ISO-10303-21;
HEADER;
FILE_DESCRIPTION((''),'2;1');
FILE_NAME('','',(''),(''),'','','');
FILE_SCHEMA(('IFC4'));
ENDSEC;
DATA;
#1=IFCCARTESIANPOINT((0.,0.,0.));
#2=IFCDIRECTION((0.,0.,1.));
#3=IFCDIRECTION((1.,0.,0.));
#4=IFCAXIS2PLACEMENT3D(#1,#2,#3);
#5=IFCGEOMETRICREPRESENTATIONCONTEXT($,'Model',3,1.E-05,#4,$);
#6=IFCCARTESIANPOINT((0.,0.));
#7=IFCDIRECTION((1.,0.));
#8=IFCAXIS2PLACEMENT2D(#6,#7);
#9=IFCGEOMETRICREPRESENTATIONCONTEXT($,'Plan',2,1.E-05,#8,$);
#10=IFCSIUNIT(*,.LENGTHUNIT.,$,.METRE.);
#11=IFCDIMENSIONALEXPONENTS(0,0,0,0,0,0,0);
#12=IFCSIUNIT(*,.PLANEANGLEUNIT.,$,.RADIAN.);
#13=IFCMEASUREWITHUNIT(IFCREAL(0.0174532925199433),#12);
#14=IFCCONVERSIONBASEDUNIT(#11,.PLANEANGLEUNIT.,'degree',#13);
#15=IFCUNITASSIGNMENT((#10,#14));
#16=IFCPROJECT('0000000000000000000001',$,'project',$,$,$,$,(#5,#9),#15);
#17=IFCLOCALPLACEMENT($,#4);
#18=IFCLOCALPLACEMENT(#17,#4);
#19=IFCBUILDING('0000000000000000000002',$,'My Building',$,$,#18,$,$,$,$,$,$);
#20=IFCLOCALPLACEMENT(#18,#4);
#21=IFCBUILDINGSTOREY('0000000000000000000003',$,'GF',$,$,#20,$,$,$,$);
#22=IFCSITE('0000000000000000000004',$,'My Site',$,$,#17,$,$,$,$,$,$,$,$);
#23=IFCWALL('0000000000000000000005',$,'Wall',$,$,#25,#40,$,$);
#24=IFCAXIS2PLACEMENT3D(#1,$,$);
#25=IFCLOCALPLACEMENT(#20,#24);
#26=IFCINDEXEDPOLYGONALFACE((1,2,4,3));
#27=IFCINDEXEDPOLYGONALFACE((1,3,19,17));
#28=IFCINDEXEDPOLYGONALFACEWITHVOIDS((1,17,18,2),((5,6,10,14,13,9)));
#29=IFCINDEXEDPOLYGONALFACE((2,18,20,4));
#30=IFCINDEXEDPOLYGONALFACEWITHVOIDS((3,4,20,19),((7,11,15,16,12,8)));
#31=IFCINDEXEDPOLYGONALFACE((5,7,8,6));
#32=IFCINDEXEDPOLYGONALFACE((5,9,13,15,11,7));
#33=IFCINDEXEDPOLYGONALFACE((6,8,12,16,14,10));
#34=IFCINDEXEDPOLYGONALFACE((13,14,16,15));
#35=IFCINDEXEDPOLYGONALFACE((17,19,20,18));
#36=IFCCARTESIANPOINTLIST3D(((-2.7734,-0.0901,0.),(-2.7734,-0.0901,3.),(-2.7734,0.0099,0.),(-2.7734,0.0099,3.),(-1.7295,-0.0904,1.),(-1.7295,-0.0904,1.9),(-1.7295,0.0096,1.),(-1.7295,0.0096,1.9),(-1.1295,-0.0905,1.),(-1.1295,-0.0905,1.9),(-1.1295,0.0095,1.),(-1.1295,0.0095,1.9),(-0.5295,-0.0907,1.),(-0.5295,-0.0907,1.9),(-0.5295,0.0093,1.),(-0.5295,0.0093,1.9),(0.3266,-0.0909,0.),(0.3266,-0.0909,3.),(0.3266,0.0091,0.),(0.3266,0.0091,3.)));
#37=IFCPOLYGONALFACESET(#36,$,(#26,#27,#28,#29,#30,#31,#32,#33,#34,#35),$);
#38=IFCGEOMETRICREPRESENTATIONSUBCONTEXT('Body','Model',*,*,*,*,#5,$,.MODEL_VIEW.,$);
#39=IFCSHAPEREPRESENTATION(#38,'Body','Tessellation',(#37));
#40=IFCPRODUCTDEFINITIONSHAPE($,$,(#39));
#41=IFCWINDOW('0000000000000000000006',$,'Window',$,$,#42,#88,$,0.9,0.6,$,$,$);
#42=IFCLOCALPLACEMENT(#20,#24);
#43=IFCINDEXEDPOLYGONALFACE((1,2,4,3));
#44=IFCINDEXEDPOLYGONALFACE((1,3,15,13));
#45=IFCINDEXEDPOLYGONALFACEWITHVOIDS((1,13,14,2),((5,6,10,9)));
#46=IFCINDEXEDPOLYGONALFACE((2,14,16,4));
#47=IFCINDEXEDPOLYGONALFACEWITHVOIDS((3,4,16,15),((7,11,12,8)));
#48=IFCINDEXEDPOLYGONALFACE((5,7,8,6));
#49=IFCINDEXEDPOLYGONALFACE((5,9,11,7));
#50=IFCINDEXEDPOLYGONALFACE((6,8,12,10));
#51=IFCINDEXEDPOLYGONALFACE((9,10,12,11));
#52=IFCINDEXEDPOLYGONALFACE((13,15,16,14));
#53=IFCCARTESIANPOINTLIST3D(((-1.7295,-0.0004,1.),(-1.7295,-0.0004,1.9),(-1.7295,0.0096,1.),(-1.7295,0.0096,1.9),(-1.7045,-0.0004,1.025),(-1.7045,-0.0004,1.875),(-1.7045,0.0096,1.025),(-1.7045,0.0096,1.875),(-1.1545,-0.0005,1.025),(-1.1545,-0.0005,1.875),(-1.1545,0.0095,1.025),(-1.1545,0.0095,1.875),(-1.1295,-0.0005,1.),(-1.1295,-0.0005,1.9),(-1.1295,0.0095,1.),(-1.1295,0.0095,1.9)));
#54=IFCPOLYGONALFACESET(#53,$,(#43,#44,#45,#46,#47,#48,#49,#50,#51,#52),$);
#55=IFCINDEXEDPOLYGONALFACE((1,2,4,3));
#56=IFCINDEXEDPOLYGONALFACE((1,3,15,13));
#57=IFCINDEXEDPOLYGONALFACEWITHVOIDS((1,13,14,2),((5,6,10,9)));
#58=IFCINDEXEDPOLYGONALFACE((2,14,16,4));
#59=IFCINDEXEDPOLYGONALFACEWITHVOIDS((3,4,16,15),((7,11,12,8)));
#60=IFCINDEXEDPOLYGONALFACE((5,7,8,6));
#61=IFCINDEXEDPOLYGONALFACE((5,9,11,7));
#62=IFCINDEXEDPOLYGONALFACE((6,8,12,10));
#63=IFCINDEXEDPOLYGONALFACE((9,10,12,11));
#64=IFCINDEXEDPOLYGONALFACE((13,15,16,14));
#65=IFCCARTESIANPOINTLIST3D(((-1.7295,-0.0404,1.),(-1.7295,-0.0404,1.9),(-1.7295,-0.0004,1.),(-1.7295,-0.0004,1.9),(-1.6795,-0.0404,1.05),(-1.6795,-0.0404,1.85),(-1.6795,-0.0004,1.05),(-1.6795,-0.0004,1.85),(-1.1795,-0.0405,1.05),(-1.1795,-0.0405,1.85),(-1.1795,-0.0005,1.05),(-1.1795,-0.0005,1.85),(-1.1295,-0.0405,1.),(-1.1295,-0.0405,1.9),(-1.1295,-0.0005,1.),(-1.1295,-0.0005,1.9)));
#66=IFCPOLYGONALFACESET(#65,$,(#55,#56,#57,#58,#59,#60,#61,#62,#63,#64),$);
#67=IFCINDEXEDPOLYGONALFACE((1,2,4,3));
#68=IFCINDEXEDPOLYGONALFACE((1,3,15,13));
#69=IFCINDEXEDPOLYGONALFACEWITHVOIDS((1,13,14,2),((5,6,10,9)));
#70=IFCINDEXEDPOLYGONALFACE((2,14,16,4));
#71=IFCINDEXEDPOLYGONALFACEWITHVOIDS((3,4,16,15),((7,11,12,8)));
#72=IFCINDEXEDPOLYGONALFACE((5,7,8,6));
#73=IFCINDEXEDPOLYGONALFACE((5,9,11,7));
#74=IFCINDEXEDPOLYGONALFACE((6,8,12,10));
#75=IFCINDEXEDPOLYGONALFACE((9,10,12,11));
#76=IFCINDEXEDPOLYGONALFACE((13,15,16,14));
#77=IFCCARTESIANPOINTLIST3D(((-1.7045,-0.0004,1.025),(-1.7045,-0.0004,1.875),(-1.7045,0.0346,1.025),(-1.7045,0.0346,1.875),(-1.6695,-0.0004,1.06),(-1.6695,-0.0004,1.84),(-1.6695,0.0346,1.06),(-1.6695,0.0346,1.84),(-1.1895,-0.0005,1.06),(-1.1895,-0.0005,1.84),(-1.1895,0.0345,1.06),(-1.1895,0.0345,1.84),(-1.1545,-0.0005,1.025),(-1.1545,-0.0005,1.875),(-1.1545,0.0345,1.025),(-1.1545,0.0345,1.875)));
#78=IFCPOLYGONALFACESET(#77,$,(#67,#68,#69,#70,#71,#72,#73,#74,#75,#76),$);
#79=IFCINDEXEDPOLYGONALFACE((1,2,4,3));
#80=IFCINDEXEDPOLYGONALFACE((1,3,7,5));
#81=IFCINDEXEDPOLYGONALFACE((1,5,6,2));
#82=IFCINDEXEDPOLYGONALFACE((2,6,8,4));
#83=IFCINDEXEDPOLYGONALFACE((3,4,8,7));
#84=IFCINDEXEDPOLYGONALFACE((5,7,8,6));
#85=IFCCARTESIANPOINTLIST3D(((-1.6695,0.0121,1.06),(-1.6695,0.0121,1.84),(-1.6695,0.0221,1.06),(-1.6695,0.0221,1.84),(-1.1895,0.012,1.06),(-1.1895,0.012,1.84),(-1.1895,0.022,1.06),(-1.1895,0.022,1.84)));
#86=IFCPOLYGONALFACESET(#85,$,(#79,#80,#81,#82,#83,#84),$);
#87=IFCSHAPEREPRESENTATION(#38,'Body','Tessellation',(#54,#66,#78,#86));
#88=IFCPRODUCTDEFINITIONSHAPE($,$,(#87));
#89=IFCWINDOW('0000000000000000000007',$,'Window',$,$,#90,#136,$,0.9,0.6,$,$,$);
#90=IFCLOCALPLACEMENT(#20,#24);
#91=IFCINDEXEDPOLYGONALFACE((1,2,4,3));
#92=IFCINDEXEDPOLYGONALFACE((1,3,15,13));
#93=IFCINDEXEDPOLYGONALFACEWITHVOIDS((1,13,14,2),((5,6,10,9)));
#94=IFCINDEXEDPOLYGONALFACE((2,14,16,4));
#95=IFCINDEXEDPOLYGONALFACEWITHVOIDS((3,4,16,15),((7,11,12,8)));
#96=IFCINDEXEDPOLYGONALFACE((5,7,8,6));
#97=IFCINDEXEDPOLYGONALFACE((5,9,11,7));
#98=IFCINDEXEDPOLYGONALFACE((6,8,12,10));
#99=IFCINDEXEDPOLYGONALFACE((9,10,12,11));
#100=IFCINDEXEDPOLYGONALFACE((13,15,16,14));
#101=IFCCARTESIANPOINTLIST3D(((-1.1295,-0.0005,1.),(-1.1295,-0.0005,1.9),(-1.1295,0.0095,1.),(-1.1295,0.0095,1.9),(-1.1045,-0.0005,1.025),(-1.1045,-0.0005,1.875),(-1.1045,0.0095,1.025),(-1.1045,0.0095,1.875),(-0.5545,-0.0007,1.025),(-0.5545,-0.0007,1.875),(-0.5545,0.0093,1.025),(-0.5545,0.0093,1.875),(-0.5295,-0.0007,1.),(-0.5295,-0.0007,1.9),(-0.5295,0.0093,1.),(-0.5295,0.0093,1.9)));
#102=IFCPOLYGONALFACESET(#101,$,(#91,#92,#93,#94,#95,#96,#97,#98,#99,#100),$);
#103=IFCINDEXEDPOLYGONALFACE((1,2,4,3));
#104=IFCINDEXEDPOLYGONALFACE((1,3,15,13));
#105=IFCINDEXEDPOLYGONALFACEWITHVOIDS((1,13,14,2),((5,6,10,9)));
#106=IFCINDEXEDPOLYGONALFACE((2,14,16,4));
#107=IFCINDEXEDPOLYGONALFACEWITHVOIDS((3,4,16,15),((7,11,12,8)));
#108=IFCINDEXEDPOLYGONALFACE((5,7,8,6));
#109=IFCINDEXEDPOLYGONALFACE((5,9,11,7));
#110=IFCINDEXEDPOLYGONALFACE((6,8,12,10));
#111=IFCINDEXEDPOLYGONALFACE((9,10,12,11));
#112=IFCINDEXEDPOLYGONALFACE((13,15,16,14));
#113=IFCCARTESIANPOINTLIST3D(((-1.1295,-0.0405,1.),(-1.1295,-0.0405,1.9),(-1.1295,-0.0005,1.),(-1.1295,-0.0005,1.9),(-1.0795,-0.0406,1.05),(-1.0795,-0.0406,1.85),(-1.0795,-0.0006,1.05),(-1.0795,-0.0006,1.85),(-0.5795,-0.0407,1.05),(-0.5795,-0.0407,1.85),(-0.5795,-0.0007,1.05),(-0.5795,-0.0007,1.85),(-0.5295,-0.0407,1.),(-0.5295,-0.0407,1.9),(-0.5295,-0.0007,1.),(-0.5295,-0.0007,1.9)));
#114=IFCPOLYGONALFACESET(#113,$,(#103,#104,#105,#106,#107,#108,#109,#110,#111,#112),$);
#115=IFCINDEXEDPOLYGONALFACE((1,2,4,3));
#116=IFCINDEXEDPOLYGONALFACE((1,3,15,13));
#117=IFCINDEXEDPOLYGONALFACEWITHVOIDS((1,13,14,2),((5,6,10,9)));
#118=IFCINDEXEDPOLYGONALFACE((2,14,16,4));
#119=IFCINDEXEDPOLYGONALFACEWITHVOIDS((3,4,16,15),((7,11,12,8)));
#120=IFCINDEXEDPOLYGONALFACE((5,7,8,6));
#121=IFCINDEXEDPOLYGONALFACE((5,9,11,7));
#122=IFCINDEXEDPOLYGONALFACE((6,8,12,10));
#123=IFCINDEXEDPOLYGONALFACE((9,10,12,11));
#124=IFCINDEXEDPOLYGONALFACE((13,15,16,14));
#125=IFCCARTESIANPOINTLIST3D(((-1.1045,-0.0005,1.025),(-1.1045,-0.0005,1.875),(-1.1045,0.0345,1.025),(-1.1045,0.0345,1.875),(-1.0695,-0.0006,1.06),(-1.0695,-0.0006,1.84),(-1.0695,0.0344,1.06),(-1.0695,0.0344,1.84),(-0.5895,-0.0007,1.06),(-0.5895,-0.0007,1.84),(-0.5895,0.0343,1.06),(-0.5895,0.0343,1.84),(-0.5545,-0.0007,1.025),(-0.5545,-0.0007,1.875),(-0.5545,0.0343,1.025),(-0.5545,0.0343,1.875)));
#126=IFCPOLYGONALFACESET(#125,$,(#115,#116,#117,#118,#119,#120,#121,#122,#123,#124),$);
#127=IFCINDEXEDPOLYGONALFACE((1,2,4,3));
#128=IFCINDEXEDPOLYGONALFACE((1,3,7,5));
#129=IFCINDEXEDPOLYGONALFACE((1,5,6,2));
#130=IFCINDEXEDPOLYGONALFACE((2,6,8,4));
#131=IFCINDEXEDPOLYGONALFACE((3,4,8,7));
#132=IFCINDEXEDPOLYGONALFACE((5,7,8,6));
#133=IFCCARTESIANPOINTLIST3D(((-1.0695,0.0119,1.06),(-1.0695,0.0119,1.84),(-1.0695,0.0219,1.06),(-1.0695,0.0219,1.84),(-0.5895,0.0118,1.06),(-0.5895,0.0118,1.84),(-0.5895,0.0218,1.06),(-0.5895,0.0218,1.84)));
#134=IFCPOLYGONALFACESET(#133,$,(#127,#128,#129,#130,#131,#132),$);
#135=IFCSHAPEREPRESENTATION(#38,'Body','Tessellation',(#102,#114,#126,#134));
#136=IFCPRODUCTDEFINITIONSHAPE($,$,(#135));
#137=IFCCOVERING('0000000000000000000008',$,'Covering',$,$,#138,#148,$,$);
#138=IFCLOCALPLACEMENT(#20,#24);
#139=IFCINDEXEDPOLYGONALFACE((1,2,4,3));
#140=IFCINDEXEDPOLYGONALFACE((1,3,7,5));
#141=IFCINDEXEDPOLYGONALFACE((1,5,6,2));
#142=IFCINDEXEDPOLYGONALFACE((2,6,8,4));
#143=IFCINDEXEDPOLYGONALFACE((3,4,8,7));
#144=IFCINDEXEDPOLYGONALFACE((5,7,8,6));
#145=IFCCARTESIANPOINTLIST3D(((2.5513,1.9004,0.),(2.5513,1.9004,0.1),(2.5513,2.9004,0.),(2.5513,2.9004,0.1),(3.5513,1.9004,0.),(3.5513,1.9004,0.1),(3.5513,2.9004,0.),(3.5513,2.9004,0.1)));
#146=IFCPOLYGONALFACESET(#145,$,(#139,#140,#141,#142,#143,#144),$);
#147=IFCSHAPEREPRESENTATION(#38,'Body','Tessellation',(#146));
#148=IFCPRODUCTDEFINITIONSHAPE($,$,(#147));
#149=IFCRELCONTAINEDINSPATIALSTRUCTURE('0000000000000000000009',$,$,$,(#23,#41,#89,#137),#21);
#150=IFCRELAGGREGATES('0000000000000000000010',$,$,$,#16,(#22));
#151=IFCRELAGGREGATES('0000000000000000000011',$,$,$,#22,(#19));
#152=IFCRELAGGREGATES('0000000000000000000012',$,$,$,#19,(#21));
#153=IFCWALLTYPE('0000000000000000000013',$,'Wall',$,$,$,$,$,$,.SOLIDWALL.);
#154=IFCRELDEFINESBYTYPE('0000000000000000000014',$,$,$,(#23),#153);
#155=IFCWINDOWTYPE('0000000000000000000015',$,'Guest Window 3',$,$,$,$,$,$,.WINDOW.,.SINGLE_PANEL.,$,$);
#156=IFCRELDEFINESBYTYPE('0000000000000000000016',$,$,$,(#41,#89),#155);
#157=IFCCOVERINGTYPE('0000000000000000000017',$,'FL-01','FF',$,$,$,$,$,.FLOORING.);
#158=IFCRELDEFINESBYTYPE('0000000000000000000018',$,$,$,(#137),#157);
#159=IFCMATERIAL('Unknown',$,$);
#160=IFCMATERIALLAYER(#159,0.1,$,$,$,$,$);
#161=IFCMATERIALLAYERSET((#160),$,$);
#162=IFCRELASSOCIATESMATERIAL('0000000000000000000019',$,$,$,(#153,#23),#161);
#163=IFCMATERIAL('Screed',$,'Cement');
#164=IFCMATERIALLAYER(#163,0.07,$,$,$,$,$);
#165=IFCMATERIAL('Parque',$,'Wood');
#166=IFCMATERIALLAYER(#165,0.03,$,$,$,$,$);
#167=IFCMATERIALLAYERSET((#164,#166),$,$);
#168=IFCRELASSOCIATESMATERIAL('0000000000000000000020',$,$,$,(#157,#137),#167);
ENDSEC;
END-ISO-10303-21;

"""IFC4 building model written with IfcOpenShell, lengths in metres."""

from ifc_helpers import new_model, entity, si_unit, converted_unit, frame, origin_with_axes, origin_2d_with_axis, place, context, subcontext, project, spatial, line, indexed_curve, outline, extrude, shape, source, transform, mapped, material, layer, layer_set, layer_usage, type_object, type_shapes, element, fill, save


model = new_model("IFC4")

# Units and contexts
model_context = context("Model", 3, precision=1e-05, world=origin_with_axes())
plan_context = context("Plan", 2, precision=1e-05, world=origin_2d_with_axis())
body_context_1 = subcontext(model_context, "Body", "Model", "MODEL_VIEW")
body_context_2 = subcontext(plan_context, "Body", "Plan", "PLAN_VIEW")
ifc_project = project(units=[si_unit("LENGTHUNIT", "METRE"), converted_unit("PLANEANGLEUNIT", "degree", entity("IfcReal", 0.0174532925199433), si_unit("PLANEANGLEUNIT", "RADIAN"), dimensions=[0, 0, 0, 0, 0, 0, 0])], contexts=[model_context, plan_context])

# Site, building, storey
site_placement = place(None, origin_with_axes())
site = spatial("IfcSite", under=ifc_project, at=site_placement, Name="My Site")
building_placement = place(site_placement, origin_with_axes())
building = spatial("IfcBuilding", under=site, at=building_placement, Name="My Building")
storey_placement = place(building_placement, origin_with_axes())
storey = spatial("IfcBuildingStorey", under=building, at=storey_placement, Name="GF")

# Shared definitions
ifc_material_1 = material(Name="Unknown")

# Shared definitions
ifc_layer_1 = layer(ifc_material_1, 0.1)
ifc_layer_set_1 = layer_set([ifc_layer_1])
wall_type = type_object("IfcWallType", Name="Wall", PredefinedType="SOLIDWALL", material=ifc_layer_set_1)

# Wall, openings, windows
ifc_layer_usage_1 = layer_usage(ifc_layer_set_1, "AXIS2", "POSITIVE", 0.0)
wall_1_placement = place(storey_placement, frame((-2.7734, -0.0901, 0.0), z_axis=(0.0, 0.0, 1.0), x_axis=(1.0, -0.000264, 0.0)))
wall_1 = element("IfcWall", 1, at=wall_1_placement, inside=storey, type_object=wall_type, material=ifc_layer_usage_1, Name="Wall", context=body_context_1, shape_type="SweptSolid", body=[
    extrude(outline(indexed_curve([(0.0, 0.0), (0.0, 0.1), (3.1, 0.1), (3.1, 0.0)], segments=[line(1, 2, 3, 4, 1)])), origin_with_axes(), (0.0, 0.0, 1.0), 3.0),
])
shared_shape_1 = source(origin_with_axes(), body_context_1, "Body", "SweptSolid", [
    extrude(outline(indexed_curve([(0.0, 0.0), (0.6, 0.0), (0.6, 0.9), (0.0, 0.9)], segments=[line(1, 2, 3, 4, 1)])), frame((0.0, -0.6, 0.0), z_axis=(0.0, -1.0, 0.0), x_axis=(1.0, 0.0, 0.0)), (0.0, 0.0, -1.0), 1.2),
])
opening_1_placement = place(wall_1_placement, frame((1.0439, 0.0, 1.0), z_axis=(0.0, 0.0, 1.0), x_axis=(1.0, 0.0, 0.0)))
opening_1 = element("IfcOpeningElement", 2, at=opening_1_placement, cuts=wall_1, PredefinedType="OPENING", context=body_context_1, shape_type="MappedRepresentation", body=[
    mapped(shared_shape_1, transform((0.0, 0.0, 0.0), x_axis=(1.0, 0.0, 0.0), y_axis=(0.0, 1.0, 0.0), z_axis=(0.0, 0.0, 1.0), scale=1.0)),
])
opening_2_placement = place(wall_1_placement, frame((1.6439, 0.0, 1.0), z_axis=(0.0, 0.0, 1.0), x_axis=(1.0, 0.0, 0.0)))
opening_2 = element("IfcOpeningElement", 3, at=opening_2_placement, cuts=wall_1, PredefinedType="OPENING", context=body_context_1, shape_type="MappedRepresentation", body=[
    mapped(shared_shape_1, transform((0.0, 0.0, 0.0), x_axis=(1.0, 0.0, 0.0), y_axis=(0.0, 1.0, 0.0), z_axis=(0.0, 0.0, 1.0), scale=1.0)),
])
window_type_1 = type_object("IfcWindowType", Name="Guest Window 3", PartitioningType="SINGLE_PANEL", PredefinedType="WINDOW")
shared_shape_2 = source(origin_with_axes(), body_context_1, "Body", "SweptSolid", [
    extrude(outline(indexed_curve([(0.0, 0.0), (0.6, 0.0), (0.6, 0.9), (0.0, 0.9)], segments=[line(1, 2, 3, 4, 1)]), holes=[indexed_curve([(0.025, 0.025), (0.575, 0.025), (0.575, 0.875), (0.025, 0.875)], segments=[line(1, 2, 3, 4, 1)])]), frame((0.0, 0.09, 0.0), z_axis=(0.0, -1.0, 0.0), x_axis=(1.0, 0.0, 0.0)), (0.0, 0.0, -1.0), 0.01),
    extrude(outline(indexed_curve([(0.0, 0.0), (0.6, 0.0), (0.6, 0.9), (0.0, 0.9)], segments=[line(1, 2, 3, 4, 1)]), holes=[indexed_curve([(0.05, 0.05), (0.55, 0.05), (0.55, 0.85), (0.05, 0.85)], segments=[line(1, 2, 3, 4, 1)])]), frame((0.0, 0.05, 0.0), z_axis=(0.0, -1.0, 0.0), x_axis=(1.0, 0.0, 0.0)), (0.0, 0.0, -1.0), 0.04),
    extrude(outline(indexed_curve([(0.0, 0.0), (0.55, 0.0), (0.55, 0.85), (0.0, 0.85)], segments=[line(1, 2, 3, 4, 1)]), holes=[indexed_curve([(0.035, 0.035), (0.515, 0.035), (0.515, 0.815), (0.035, 0.815)], segments=[line(1, 2, 3, 4, 1)])]), frame((0.025, 0.09, 0.025), z_axis=(0.0, -1.0, 0.0), x_axis=(1.0, 0.0, 0.0)), (0.0, 0.0, -1.0), 0.035),
    extrude(outline(indexed_curve([(0.035, 0.035), (0.515, 0.035), (0.515, 0.815), (0.035, 0.815)], segments=[line(1, 2, 3, 4, 1)])), frame((0.025, 0.1025, 0.025), z_axis=(0.0, -1.0, 0.0), x_axis=(1.0, 0.0, 0.0)), (0.0, 0.0, -1.0), 0.01),
])
shared_shape_3 = source(origin_with_axes(), body_context_2, "Body", "Curve2D", [
    entity("IfcIndexedPolyCurve", entity("IfcCartesianPointList2D", [[0.05, 0.05], [0.55, 0.05]])),
    entity("IfcIndexedPolyCurve", entity("IfcCartesianPointList2D", [[0.0, 0.1], [0.025, 0.1], [0.025, 0.09], [0.05, 0.09], [0.05, 0.05], [0.0, 0.05]]), [entity("IfcLineIndex", [1, 2, 3, 4, 5, 6, 1])]),
    entity("IfcIndexedPolyCurve", entity("IfcCartesianPointList2D", [[0.6, 0.1], [0.575, 0.1], [0.575, 0.09], [0.55, 0.09], [0.55, 0.05], [0.6, 0.05]]), [entity("IfcLineIndex", [1, 2, 3, 4, 5, 6, 1])]),
    entity("IfcIndexedPolyCurve", entity("IfcCartesianPointList2D", [[0.025, 0.09], [0.06, 0.09], [0.06, 0.125], [0.025, 0.125]]), [entity("IfcLineIndex", [1, 2, 3, 4, 1])]),
    entity("IfcIndexedPolyCurve", entity("IfcCartesianPointList2D", [[0.575, 0.09], [0.54, 0.09], [0.54, 0.125], [0.575, 0.125]]), [entity("IfcLineIndex", [1, 2, 3, 4, 1])]),
    entity("IfcIndexedPolyCurve", entity("IfcCartesianPointList2D", [[0.06, 0.09], [0.54, 0.09]])),
    entity("IfcIndexedPolyCurve", entity("IfcCartesianPointList2D", [[0.06, 0.125], [0.54, 0.125]])),
    entity("IfcIndexedPolyCurve", entity("IfcCartesianPointList2D", [[0.06, 0.1075], [0.54, 0.1075]])),
])
type_shapes(window_type_1, [shared_shape_2, shared_shape_3])
window_1_placement = place(opening_1_placement, frame((0.0, 0.0, 0.0), z_axis=(0.0, 0.0, 1.0), x_axis=(1.0, 0.0, 0.0)))
window_1 = element("IfcWindow", 4, at=window_1_placement, inside=storey, type_object=window_type_1, Name="Window", OverallHeight=0.9, OverallWidth=0.6, shapes=[
    shape(body_context_1, "Body", "MappedRepresentation", [mapped(shared_shape_2, transform((0.0, 0.0, 0.0), x_axis=(1.0, 0.0, 0.0), y_axis=(0.0, 1.0, 0.0), z_axis=(0.0, 0.0, 1.0), scale=1.0))]),
    shape(body_context_2, "Body", "MappedRepresentation", [mapped(shared_shape_3, transform((0.0, 0.0, 0.0), x_axis=(1.0, 0.0, 0.0), y_axis=(0.0, 1.0, 0.0), z_axis=(0.0, 0.0, 1.0), scale=1.0))]),
])
fill(opening_1, window_1)
window_2_placement = place(opening_2_placement, frame((0.0, 0.0, 0.0), z_axis=(0.0, 0.0, 1.0), x_axis=(1.0, 0.0, 0.0)))
window_2 = element("IfcWindow", 5, at=window_2_placement, inside=storey, type_object=window_type_1, Name="Window", OverallHeight=0.9, OverallWidth=0.6, shapes=[
    shape(body_context_1, "Body", "MappedRepresentation", [mapped(shared_shape_2, transform((0.0, 0.0, 0.0), x_axis=(1.0, 0.0, 0.0), y_axis=(0.0, 1.0, 0.0), z_axis=(0.0, 0.0, 1.0), scale=1.0))]),
    shape(body_context_2, "Body", "MappedRepresentation", [mapped(shared_shape_3, transform((0.0, 0.0, 0.0), x_axis=(1.0, 0.0, 0.0), y_axis=(0.0, 1.0, 0.0), z_axis=(0.0, 0.0, 1.0), scale=1.0))]),
])
fill(opening_2, window_2)

# Covering
ifc_material_2 = material(Name="Screed", Category="Cement")
ifc_layer_2 = layer(ifc_material_2, 0.07)
ifc_material_3 = material(Name="Parque", Category="Wood")
ifc_layer_3 = layer(ifc_material_3, 0.03)
ifc_layer_set_2 = layer_set([ifc_layer_2, ifc_layer_3])
ifc_layer_usage_2 = layer_usage(ifc_layer_set_2, "AXIS3", "POSITIVE", 0.0)
covering_type = type_object("IfcCoveringType", Name="FL-01", Description="FF", PredefinedType="FLOORING", material=ifc_layer_set_2)
covering_placement = place(storey_placement, frame((2.5513, 1.9004, 0.0), z_axis=(0.0, 0.0, 1.0), x_axis=(1.0, 0.0, 0.0)))
element("IfcCovering", 6, at=covering_placement, inside=storey, type_object=covering_type, material=ifc_layer_usage_2, Name="Covering", context=body_context_1, shape_type="SweptSolid", body=[
    extrude(outline(indexed_curve([(0.0, 0.0), (1.0, 0.0), (1.0, 1.0), (0.0, 1.0), (0.0, 0.0)])), None, (0.0, 0.0, 1.0), 0.1),
])

save(model, "model.ifc")
